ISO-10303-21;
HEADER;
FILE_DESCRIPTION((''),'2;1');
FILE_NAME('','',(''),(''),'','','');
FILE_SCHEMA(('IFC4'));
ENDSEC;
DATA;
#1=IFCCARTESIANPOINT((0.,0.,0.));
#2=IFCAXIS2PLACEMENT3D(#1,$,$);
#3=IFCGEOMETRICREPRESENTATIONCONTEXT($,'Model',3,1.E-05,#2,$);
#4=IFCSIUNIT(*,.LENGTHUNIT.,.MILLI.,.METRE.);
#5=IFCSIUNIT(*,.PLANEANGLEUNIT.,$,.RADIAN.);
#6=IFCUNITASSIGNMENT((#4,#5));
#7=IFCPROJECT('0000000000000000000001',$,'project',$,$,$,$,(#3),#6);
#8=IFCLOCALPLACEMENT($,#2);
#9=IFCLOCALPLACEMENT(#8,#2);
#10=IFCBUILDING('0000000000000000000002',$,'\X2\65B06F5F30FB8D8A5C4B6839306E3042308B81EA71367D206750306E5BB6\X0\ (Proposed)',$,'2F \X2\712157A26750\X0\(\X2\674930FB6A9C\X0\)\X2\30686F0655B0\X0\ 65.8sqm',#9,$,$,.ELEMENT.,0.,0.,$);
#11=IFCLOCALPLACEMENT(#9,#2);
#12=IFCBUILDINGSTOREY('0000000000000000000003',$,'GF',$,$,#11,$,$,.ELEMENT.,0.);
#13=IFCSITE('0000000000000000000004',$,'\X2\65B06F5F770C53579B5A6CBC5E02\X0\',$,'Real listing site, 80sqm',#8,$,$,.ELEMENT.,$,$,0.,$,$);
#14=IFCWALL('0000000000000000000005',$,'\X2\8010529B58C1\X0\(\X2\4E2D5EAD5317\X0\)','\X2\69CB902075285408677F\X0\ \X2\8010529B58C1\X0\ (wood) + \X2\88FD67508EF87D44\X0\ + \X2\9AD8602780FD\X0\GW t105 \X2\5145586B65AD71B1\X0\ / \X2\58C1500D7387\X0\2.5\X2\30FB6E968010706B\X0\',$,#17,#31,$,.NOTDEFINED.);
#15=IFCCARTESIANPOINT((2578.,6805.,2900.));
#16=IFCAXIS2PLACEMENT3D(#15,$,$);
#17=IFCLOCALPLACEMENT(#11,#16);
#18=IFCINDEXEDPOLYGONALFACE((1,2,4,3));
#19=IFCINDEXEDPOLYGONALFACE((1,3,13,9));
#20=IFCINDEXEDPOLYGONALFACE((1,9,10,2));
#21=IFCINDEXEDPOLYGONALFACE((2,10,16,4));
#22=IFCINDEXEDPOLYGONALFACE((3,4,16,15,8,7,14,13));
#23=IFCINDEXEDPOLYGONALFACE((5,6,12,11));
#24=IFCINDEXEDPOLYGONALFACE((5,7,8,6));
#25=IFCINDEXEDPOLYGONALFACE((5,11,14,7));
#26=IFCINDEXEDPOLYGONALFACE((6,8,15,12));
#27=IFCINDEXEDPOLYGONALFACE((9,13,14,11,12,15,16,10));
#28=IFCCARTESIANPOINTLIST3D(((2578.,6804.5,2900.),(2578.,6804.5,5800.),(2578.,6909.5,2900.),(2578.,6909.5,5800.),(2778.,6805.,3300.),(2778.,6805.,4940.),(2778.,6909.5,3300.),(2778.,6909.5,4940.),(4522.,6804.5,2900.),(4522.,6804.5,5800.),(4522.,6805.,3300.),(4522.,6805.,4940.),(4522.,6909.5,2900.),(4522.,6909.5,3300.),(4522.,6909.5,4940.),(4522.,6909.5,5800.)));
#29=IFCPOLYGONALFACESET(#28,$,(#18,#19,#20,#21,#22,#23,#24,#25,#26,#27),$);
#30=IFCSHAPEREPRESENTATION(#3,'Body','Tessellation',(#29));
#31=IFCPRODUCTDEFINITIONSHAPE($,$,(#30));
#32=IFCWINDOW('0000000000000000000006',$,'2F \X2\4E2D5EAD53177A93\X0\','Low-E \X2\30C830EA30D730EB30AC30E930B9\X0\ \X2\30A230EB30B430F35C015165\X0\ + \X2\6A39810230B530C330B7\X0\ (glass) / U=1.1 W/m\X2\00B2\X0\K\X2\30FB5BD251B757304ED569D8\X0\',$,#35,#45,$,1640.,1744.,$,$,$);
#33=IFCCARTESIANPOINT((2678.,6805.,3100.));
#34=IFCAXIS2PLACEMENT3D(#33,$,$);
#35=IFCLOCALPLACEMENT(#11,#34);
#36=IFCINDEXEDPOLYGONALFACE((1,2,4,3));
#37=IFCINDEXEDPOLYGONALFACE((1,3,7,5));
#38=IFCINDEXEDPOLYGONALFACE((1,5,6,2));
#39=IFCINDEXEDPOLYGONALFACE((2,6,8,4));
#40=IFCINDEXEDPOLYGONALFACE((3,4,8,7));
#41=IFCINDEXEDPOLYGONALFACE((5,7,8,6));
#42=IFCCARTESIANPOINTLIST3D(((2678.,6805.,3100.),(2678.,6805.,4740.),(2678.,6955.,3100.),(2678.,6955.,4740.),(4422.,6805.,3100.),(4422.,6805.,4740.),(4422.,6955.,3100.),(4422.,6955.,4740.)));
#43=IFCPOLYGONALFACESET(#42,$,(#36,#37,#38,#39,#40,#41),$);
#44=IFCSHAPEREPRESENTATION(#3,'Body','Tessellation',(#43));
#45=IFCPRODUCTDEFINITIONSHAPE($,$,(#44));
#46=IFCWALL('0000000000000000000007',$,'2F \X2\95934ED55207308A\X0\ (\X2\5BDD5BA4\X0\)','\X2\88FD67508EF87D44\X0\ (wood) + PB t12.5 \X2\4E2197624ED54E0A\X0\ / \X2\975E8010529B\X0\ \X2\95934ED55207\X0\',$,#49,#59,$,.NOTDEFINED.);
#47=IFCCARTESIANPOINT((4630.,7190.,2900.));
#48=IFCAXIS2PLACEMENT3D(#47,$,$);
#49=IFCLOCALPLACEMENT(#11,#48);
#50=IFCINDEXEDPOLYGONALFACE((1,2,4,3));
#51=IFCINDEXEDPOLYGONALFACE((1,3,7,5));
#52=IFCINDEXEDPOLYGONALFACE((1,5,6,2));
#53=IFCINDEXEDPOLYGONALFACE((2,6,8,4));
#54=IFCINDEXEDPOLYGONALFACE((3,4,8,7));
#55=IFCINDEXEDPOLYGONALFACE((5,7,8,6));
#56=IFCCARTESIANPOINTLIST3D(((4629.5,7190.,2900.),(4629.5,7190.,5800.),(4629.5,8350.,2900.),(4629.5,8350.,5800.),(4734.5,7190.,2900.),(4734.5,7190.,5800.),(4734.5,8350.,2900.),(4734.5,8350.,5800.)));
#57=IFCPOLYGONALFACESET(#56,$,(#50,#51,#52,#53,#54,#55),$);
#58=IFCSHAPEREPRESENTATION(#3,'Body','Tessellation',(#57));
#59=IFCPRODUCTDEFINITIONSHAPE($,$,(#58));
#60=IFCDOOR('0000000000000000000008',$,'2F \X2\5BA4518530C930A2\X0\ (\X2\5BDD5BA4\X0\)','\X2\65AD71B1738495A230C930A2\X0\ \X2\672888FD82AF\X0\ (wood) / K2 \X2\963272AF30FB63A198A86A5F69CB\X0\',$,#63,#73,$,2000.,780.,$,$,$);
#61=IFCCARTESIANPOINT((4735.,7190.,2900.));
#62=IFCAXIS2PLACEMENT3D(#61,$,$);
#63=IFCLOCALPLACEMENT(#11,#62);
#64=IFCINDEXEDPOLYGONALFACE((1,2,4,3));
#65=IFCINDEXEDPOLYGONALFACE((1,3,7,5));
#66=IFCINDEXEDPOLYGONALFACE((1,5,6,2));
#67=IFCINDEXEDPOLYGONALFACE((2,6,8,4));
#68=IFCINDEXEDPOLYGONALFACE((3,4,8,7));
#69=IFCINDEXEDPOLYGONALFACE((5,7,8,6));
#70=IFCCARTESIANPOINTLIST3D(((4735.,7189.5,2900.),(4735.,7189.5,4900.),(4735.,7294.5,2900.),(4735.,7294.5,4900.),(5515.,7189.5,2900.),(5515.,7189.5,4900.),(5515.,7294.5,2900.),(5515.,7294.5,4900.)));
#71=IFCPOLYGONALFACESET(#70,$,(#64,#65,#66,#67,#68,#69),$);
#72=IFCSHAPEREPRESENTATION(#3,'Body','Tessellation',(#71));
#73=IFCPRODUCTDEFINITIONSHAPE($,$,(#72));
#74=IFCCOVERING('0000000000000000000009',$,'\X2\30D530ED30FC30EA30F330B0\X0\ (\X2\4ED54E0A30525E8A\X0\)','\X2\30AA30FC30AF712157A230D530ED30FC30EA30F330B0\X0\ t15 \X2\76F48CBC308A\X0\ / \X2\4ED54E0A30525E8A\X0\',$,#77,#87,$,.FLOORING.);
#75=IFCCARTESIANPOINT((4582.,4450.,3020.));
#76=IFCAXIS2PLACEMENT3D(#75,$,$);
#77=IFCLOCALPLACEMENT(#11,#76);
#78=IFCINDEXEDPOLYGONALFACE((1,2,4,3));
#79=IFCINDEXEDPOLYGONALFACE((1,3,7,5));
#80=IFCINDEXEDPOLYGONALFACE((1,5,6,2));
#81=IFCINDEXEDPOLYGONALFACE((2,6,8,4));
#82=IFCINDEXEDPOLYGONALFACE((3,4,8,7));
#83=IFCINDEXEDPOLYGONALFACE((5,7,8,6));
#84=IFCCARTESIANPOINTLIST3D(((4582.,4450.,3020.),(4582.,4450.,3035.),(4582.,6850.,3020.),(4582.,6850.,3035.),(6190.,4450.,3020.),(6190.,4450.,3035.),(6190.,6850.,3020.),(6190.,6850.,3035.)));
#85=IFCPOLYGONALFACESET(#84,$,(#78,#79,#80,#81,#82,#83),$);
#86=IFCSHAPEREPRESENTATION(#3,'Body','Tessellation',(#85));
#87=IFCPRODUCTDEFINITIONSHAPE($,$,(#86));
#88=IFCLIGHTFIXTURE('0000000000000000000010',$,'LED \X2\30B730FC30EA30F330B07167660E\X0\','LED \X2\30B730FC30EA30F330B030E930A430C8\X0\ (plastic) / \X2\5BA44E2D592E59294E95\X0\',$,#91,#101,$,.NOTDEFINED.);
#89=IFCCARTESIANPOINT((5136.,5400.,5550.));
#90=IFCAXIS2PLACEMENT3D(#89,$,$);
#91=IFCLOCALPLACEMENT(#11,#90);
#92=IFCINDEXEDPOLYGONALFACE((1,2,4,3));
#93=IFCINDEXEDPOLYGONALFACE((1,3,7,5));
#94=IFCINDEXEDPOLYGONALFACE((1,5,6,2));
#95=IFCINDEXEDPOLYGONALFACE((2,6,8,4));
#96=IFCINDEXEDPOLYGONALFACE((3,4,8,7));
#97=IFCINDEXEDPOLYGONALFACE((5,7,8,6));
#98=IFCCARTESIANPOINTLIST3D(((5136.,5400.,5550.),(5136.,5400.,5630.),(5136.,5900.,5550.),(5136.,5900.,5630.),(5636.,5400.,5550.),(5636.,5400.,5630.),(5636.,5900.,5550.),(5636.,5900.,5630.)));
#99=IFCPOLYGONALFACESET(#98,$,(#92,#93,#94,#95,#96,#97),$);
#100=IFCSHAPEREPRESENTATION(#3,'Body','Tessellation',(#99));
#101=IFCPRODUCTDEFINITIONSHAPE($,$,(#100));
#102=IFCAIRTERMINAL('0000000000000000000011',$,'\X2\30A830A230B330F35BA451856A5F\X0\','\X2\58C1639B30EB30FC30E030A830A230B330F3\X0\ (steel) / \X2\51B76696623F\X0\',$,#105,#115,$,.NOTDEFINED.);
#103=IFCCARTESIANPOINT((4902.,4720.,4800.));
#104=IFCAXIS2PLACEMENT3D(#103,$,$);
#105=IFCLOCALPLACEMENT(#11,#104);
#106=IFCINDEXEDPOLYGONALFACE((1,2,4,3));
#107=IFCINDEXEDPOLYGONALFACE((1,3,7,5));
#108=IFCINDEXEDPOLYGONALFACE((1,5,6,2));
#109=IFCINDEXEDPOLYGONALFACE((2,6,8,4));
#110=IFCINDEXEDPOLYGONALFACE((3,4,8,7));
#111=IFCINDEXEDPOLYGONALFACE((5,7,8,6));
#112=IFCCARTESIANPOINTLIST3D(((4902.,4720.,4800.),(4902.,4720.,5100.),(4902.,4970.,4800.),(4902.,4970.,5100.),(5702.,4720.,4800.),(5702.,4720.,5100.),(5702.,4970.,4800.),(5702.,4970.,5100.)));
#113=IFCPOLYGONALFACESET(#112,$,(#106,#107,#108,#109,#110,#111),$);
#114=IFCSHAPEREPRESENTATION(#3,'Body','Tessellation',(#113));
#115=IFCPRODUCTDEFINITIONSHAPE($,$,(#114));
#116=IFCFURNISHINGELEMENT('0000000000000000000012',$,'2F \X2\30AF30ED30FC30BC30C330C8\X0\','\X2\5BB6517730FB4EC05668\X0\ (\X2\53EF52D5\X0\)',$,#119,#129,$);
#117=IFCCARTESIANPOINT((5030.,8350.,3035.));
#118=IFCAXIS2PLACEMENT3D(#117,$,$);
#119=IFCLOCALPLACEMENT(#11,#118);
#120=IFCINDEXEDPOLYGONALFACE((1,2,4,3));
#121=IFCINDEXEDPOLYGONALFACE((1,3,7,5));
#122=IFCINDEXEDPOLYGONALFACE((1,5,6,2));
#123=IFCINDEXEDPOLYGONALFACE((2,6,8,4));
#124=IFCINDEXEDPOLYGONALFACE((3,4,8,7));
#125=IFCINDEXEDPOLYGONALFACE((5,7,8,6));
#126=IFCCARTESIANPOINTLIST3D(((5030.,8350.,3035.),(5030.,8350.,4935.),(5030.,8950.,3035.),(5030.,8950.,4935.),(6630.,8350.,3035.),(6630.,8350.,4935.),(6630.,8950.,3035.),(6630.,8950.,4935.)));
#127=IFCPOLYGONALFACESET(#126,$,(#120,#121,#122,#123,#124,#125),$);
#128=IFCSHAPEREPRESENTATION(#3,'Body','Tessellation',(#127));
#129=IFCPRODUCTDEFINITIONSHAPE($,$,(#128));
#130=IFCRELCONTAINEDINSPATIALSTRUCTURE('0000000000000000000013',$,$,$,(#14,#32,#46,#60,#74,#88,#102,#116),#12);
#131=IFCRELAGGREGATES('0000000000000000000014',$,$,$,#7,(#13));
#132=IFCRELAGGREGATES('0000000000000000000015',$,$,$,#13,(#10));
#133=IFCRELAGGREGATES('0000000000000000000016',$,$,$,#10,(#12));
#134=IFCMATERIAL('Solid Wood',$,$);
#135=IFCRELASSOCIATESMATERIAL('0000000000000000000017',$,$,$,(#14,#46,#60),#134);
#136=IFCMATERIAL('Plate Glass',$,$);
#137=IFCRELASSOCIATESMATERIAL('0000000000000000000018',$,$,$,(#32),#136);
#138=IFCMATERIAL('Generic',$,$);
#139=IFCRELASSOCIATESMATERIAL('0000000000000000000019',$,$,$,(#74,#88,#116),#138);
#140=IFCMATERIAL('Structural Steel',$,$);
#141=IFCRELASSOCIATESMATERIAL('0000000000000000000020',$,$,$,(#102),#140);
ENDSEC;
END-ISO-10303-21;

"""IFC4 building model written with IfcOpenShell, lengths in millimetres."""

from ifc_helpers import new_model, si_unit, frame, frame_2d, origin, place, context, project, spatial, rectangle, extrude, material, element, fill, save


model = new_model("IFC4")

# Units and contexts
model_context = context("Model", 3, precision=1e-05, world=origin())
ifc_project = project(units=[si_unit("LENGTHUNIT", "METRE", prefix="MILLI"), si_unit("PLANEANGLEUNIT", "RADIAN")], contexts=[model_context])

# Site, building, storey
site_placement = place(None, origin())
site = spatial("IfcSite", under=ifc_project, at=site_placement, Name="新潟県南魚沼市", ObjectType="Real listing site, 80sqm", CompositionType="ELEMENT", RefElevation=0.0)
building_placement = place(site_placement, origin())
building = spatial("IfcBuilding", under=site, at=building_placement, Name="新潟・越屋根のある自然素材の家 (Proposed)", ObjectType="2F 無垢材(杉・檜)と漆喰 65.8sqm", CompositionType="ELEMENT", ElevationOfRefHeight=0.0, ElevationOfTerrain=0.0)
storey_placement = place(building_placement, origin())
storey = spatial("IfcBuildingStorey", under=building, at=storey_placement, Name="GF", CompositionType="ELEMENT", Elevation=0.0)

# Shared definitions
ifc_material_1 = material(Name="Solid Wood")

# Wall, opening, window
wall_1_placement = place(storey_placement, frame((2578.0, 6805.0, 2900.0)))
wall_1 = element("IfcWall", 1, at=wall_1_placement, inside=storey, material=ifc_material_1, Name="耐力壁(中庭北)", Description="構造用合板 耐力壁 (wood) + 製材軸組 + 高性能GW t105 充填断熱 / 壁倍率2.5・準耐火", PredefinedType="NOTDEFINED", context=model_context, shape_type="SweptSolid", body=[
    extrude(rectangle(XDim=1944.0, YDim=105.0, at=frame_2d((972.0, 52.0))), frame((2578.0, 6805.0, 2900.0)), (0.0, 0.0, 1.0), 2900.0),
])
opening_placement = place(storey_placement, frame((2678.0, 6805.0, 3100.0)))
opening = element("IfcOpeningElement", 2, at=opening_placement, cuts=wall_1, PredefinedType="NOTDEFINED", context=model_context, shape_type="SweptSolid", body=[
    extrude(rectangle(XDim=1744.0, YDim=150.0, at=frame_2d((872.0, 75.0))), frame((2678.0, 6805.0, 3100.0)), (0.0, 0.0, 1.0), 1640.0),
])
ifc_material_2 = material(Name="Plate Glass")
window_placement = place(storey_placement, frame((2678.0, 6805.0, 3100.0)))
window = element("IfcWindow", 3, at=window_placement, inside=storey, material=ifc_material_2, Name="2F 中庭北窓", Description="Low-E トリプルガラス アルゴン封入 + 樹脂サッシ (glass) / U=1.1 W/m²K・寒冷地仕様", OverallHeight=1640.0, OverallWidth=1744.0, context=model_context, shape_type="SweptSolid", body=[
    extrude(rectangle(XDim=1744.0, YDim=150.0, at=frame_2d((872.0, 75.0))), frame((2678.0, 6805.0, 3100.0)), (0.0, 0.0, 1.0), 1640.0),
])
fill(opening, window)

# Wall
wall_2_placement = place(storey_placement, frame((4630.0, 7190.0, 2900.0)))
element("IfcWall", 4, at=wall_2_placement, inside=storey, material=ifc_material_1, Name="2F 間仕切り (寝室)", Description="製材軸組 (wood) + PB t12.5 両面仕上 / 非耐力 間仕切", PredefinedType="NOTDEFINED", context=model_context, shape_type="SweptSolid", body=[
    extrude(rectangle(XDim=105.0, YDim=1160.0, at=frame_2d((52.0, 580.0))), frame((4630.0, 7190.0, 2900.0)), (0.0, 0.0, 1.0), 2900.0),
])

# Door
door_placement = place(storey_placement, frame((4735.0, 7190.0, 2900.0)))
element("IfcDoor", 5, at=door_placement, inside=storey, material=ifc_material_1, Name="2F 室内ドア (寝室)", Description="断熱玄関ドア 木製芯 (wood) / K2 防犯・採風機構", OverallHeight=2000.0, OverallWidth=780.0, context=model_context, shape_type="SweptSolid", body=[
    extrude(rectangle(XDim=780.0, YDim=105.0, at=frame_2d((390.0, 52.0))), frame((4735.0, 7190.0, 2900.0)), (0.0, 0.0, 1.0), 2000.0),
])

# Covering
ifc_material_3 = material(Name="Generic")
covering_placement = place(storey_placement, frame((4582.0, 4450.0, 3020.0)))
element("IfcCovering", 6, at=covering_placement, inside=storey, material=ifc_material_3, Name="フローリング (仕上げ床)", Description="オーク無垢フローリング t15 直貼り / 仕上げ床", PredefinedType="FLOORING", context=model_context, shape_type="SweptSolid", body=[
    extrude(rectangle(XDim=1608.0, YDim=2400.0, at=frame_2d((804.0, 1200.0))), frame((4582.0, 4450.0, 3020.0)), (0.0, 0.0, 1.0), 15.0),
])

# Light fixture
light_fixture_placement = place(storey_placement, frame((5136.0, 5400.0, 5550.0)))
element("IfcLightFixture", 7, at=light_fixture_placement, inside=storey, material=ifc_material_3, Name="LED シーリング照明", Description="LED シーリングライト (plastic) / 室中央天井", PredefinedType="NOTDEFINED", context=model_context, shape_type="SweptSolid", body=[
    extrude(rectangle(XDim=500.0, YDim=500.0, at=frame_2d((250.0, 250.0))), frame((5136.0, 5400.0, 5550.0)), (0.0, 0.0, 1.0), 80.0),
])

# Air terminal
ifc_material_4 = material(Name="Structural Steel")
air_terminal_placement = place(storey_placement, frame((4902.0, 4720.0, 4800.0)))
element("IfcAirTerminal", 8, at=air_terminal_placement, inside=storey, material=ifc_material_4, Name="エアコン室内機", Description="壁掛ルームエアコン (steel) / 冷暖房", PredefinedType="NOTDEFINED", context=model_context, shape_type="SweptSolid", body=[
    extrude(rectangle(XDim=800.0, YDim=250.0, at=frame_2d((400.0, 125.0))), frame((4902.0, 4720.0, 4800.0)), (0.0, 0.0, 1.0), 300.0),
])

# Furnishing element
furnishing_placement = place(storey_placement, frame((5030.0, 8350.0, 3035.0)))
element("IfcFurnishingElement", 9, at=furnishing_placement, inside=storey, material=ifc_material_3, Name="2F クローゼット", Description="家具・什器 (可動)", context=model_context, shape_type="SweptSolid", body=[
    extrude(rectangle(XDim=1600.0, YDim=600.0, at=frame_2d((800.0, 300.0))), frame((5030.0, 8350.0, 3035.0)), (0.0, 0.0, 1.0), 1900.0),
])

save(model, "model.ifc")
